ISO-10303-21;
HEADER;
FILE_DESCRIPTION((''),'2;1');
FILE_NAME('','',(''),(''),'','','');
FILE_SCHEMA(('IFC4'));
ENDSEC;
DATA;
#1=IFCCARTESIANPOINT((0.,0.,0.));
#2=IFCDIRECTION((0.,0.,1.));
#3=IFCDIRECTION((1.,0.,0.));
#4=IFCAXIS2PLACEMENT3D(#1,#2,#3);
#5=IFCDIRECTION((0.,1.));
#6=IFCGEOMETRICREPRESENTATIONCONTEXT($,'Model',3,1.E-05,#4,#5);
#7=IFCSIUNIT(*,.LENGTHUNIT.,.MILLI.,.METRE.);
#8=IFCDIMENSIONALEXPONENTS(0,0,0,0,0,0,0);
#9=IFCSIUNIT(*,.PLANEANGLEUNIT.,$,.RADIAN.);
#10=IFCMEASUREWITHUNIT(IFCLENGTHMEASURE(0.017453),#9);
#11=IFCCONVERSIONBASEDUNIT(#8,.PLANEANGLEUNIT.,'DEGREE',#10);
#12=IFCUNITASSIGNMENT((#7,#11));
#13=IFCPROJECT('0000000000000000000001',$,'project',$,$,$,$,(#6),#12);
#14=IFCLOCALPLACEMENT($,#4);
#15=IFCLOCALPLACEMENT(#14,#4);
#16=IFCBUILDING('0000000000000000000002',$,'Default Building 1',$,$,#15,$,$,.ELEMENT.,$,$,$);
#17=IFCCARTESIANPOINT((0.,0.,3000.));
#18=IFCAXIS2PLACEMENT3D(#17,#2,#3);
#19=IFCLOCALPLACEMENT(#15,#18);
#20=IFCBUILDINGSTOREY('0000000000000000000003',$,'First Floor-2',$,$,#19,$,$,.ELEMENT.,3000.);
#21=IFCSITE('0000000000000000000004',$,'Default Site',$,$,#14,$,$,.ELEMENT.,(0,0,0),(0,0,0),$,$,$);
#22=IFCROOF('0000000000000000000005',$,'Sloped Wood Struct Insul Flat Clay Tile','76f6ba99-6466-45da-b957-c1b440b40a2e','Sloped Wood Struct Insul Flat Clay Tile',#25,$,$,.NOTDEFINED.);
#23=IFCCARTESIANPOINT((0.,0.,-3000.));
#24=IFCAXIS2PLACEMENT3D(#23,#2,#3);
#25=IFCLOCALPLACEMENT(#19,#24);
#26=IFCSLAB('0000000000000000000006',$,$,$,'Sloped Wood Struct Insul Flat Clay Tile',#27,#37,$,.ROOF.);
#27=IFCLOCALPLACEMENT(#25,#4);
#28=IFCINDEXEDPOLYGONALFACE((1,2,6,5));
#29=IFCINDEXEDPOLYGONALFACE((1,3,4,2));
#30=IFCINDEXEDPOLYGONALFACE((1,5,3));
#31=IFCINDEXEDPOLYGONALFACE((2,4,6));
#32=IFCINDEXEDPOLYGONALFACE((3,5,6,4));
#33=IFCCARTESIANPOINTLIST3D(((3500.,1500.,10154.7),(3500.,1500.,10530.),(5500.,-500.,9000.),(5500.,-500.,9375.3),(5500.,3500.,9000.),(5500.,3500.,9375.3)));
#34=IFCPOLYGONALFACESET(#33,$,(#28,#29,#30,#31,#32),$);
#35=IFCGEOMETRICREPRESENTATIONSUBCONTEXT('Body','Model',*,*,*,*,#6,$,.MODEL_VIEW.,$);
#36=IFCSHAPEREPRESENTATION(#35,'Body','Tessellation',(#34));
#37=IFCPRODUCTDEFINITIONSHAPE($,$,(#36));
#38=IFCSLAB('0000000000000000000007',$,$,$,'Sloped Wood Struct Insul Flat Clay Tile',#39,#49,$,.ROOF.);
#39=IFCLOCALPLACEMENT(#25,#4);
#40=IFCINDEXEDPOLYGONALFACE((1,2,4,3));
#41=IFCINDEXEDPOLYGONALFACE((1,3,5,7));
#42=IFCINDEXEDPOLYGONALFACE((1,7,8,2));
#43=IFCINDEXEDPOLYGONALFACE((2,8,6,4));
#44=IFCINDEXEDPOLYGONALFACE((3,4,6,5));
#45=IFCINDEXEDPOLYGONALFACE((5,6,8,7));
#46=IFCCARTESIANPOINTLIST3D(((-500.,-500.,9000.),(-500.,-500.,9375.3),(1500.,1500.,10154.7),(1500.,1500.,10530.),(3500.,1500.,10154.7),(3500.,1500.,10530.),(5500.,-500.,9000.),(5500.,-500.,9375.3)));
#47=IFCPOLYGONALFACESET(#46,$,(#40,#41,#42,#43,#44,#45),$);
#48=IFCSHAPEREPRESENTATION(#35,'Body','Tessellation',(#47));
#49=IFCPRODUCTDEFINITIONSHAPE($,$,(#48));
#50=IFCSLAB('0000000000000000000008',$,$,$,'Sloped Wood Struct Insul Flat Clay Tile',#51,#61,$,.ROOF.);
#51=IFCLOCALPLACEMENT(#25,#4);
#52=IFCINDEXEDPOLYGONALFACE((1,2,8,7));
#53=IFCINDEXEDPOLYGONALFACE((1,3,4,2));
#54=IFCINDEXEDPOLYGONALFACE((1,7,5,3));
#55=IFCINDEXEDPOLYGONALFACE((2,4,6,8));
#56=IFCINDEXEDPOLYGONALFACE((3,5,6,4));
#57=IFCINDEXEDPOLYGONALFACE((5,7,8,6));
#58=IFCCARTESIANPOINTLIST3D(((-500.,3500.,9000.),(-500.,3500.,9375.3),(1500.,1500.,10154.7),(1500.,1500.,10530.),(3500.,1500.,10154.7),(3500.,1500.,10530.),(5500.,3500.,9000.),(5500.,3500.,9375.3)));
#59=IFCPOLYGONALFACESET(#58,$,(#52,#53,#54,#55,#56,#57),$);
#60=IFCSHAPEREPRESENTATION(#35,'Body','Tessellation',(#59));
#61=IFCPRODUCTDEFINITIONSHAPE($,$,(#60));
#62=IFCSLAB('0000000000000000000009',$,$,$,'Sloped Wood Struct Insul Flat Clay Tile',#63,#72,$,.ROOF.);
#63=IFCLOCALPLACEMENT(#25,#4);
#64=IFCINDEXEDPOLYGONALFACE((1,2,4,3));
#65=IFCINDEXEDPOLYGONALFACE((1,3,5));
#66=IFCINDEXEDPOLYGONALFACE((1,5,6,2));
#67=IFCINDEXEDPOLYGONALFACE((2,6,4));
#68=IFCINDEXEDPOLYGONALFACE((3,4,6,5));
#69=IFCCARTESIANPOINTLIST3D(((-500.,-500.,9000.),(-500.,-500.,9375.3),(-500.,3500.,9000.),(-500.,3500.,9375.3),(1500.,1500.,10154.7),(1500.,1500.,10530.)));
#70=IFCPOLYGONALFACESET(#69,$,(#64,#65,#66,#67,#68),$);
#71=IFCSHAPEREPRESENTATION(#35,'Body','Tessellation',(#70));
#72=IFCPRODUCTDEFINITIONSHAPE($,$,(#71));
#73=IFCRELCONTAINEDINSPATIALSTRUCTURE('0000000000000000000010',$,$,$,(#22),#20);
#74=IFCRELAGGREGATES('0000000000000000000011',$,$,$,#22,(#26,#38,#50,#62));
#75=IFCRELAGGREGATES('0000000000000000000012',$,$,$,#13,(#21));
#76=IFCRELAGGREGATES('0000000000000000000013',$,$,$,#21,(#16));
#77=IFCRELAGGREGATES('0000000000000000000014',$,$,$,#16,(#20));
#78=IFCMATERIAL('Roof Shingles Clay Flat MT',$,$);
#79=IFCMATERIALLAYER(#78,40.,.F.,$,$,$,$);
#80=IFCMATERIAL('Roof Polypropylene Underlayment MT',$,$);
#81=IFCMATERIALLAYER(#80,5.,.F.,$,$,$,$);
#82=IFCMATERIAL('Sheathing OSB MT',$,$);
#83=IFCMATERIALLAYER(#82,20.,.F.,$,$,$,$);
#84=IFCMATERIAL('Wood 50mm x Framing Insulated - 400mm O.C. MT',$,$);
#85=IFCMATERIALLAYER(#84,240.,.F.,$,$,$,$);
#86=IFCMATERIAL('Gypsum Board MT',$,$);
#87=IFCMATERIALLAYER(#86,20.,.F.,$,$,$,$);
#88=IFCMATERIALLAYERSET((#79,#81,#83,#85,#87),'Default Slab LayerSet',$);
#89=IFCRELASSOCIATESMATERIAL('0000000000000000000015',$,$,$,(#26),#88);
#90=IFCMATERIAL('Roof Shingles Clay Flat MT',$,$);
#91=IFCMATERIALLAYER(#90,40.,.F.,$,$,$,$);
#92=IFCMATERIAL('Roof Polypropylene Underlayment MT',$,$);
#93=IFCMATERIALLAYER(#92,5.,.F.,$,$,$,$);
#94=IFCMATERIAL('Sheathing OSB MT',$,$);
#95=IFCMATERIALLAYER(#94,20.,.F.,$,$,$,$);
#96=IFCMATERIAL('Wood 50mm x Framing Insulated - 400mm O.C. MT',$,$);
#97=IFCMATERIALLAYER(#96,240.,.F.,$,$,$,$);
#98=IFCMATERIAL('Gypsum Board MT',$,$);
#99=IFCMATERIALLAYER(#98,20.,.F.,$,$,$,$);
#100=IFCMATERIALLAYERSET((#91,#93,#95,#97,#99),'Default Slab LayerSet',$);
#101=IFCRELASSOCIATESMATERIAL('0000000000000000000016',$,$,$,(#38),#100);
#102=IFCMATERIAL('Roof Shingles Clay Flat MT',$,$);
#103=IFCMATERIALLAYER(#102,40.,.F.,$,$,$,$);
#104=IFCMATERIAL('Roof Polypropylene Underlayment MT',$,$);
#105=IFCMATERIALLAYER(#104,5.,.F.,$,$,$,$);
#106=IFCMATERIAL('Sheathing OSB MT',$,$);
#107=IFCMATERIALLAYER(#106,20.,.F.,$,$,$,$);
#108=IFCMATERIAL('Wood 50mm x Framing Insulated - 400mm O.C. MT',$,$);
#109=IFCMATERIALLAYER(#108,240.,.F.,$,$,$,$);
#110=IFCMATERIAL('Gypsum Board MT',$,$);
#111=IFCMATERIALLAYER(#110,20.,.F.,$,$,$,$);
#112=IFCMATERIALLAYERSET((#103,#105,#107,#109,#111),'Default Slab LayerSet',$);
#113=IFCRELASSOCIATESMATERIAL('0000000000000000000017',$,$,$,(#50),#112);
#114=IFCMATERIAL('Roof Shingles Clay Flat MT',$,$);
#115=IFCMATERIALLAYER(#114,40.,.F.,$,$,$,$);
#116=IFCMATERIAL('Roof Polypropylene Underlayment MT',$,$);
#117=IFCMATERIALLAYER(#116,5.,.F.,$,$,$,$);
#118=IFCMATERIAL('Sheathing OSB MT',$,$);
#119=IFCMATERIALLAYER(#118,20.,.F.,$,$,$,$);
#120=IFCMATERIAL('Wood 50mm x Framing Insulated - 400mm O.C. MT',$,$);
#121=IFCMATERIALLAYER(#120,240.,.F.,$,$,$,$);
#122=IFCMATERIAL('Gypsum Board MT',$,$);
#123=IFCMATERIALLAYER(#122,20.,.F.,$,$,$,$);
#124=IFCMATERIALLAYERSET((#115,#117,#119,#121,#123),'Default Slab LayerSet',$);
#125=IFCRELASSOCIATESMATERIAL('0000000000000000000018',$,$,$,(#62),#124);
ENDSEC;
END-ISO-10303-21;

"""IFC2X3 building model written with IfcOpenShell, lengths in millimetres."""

from ifc_helpers import new_model, entity, si_unit, converted_unit, direction, frame, origin_with_axes, place, context, subcontext, project, spatial, polyline, outline, extrude, material, layer, layer_set, layer_usage, element, aggregate, save


model = new_model("IFC2X3")

# Units and contexts
model_context = context("Model", 3, precision=1e-05, world=origin_with_axes(), true_north=direction((0.0, 1.0)))
body_context = subcontext(model_context, "Body", "Model", "MODEL_VIEW")
ifc_project = project(units=[si_unit("LENGTHUNIT", "METRE", prefix="MILLI"), converted_unit("PLANEANGLEUNIT", "DEGREE", entity("IfcLengthMeasure", 0.017453), si_unit("PLANEANGLEUNIT", "RADIAN"), dimensions=[0, 0, 0, 0, 0, 0, 0])], contexts=[model_context])

# Site, building, storey
site_placement = place(None, origin_with_axes())
site = spatial("IfcSite", under=ifc_project, at=site_placement, Name="Default Site", CompositionType="ELEMENT", RefLatitude=(0, 0, 0), RefLongitude=(0, 0, 0))
building_placement = place(site_placement, origin_with_axes())
building = spatial("IfcBuilding", under=site, at=building_placement, Name="Default Building 1", CompositionType="ELEMENT")
storey_placement = place(building_placement, frame((0.0, 0.0, 3000.0), z_axis=(0.0, 0.0, 1.0), x_axis=(1.0, 0.0, 0.0)))
storey = spatial("IfcBuildingStorey", under=building, at=storey_placement, Name="First Floor-2", CompositionType="ELEMENT", Elevation=3000.0)

# Roof, slabs
roof_placement = place(storey_placement, frame((0.0, 0.0, -3000.0), z_axis=(0.0, 0.0, 1.0), x_axis=(1.0, 0.0, 0.0)))
roof = element("IfcRoof", 1, at=roof_placement, inside=storey, Name="Sloped Wood Struct Insul Flat Clay Tile", Description="76f6ba99-6466-45da-b957-c1b440b40a2e", ObjectType="Sloped Wood Struct Insul Flat Clay Tile", ShapeType="NOTDEFINED")
ifc_material_1 = material(Name="Roof Shingles Clay Flat MT")
ifc_layer_1 = layer(ifc_material_1, 40.0, ventilated=False)
ifc_material_2 = material(Name="Roof Polypropylene Underlayment MT")
ifc_layer_2 = layer(ifc_material_2, 5.0, ventilated=False)
ifc_material_3 = material(Name="Sheathing OSB MT")
ifc_layer_3 = layer(ifc_material_3, 20.0, ventilated=False)
ifc_material_4 = material(Name="Wood 50mm x Framing Insulated - 400mm O.C. MT")
ifc_layer_4 = layer(ifc_material_4, 240.0, ventilated=False)
ifc_material_5 = material(Name="Gypsum Board MT")
ifc_layer_5 = layer(ifc_material_5, 20.0, ventilated=False)
ifc_layer_set_1 = layer_set([ifc_layer_1, ifc_layer_2, ifc_layer_3, ifc_layer_4, ifc_layer_5], Name="Default Slab LayerSet")
ifc_layer_usage_1 = layer_usage(ifc_layer_set_1, "AXIS3", "POSITIVE", 260.0)
slab_1_placement = place(roof_placement, origin_with_axes())
slab_1 = element("IfcSlab", 2, at=slab_1_placement, material=ifc_layer_usage_1, ObjectType="Sloped Wood Struct Insul Flat Clay Tile", PredefinedType="ROOF", context=body_context, shape_type="SweptSolid", body=[
    extrude(outline(polyline([(0.0, 0.0), (3055.1, 0.0), (2618.6, 3023.7), (0.0, 0.0)])), frame((5500.0, -500.0, 9000.0), z_axis=(-0.5, 0.0, -0.866025), x_axis=(-0.654654, 0.654654, 0.377964)), (0.377964, -0.327327, -0.866025), 375.3),
])
ifc_material_6 = material(Name="Roof Shingles Clay Flat MT")
ifc_layer_6 = layer(ifc_material_6, 40.0, ventilated=False)
ifc_material_7 = material(Name="Roof Polypropylene Underlayment MT")
ifc_layer_7 = layer(ifc_material_7, 5.0, ventilated=False)
ifc_material_8 = material(Name="Sheathing OSB MT")
ifc_layer_8 = layer(ifc_material_8, 20.0, ventilated=False)
ifc_material_9 = material(Name="Wood 50mm x Framing Insulated - 400mm O.C. MT")
ifc_layer_9 = layer(ifc_material_9, 240.0, ventilated=False)
ifc_material_10 = material(Name="Gypsum Board MT")
ifc_layer_10 = layer(ifc_material_10, 20.0, ventilated=False)
ifc_layer_set_2 = layer_set([ifc_layer_6, ifc_layer_7, ifc_layer_8, ifc_layer_9, ifc_layer_10], Name="Default Slab LayerSet")
ifc_layer_usage_2 = layer_usage(ifc_layer_set_2, "AXIS3", "POSITIVE", 260.0)
slab_2_placement = place(roof_placement, origin_with_axes())
slab_2 = element("IfcSlab", 3, at=slab_2_placement, material=ifc_layer_usage_2, ObjectType="Sloped Wood Struct Insul Flat Clay Tile", PredefinedType="ROOF", context=body_context, shape_type="SweptSolid", body=[
    extrude(outline(polyline([(0.0, 0.0), (6000.0, 0.0), (4000.0, 2309.4), (2000.0, 2309.4), (0.0, 0.0)])), frame((5500.0, -500.0, 9000.0), z_axis=(0.0, 0.5, -0.866025), x_axis=(-1.0, 0.0, 0.0)), (0.0, 0.5, -0.866025), 375.3),
])
ifc_material_11 = material(Name="Roof Shingles Clay Flat MT")
ifc_layer_11 = layer(ifc_material_11, 40.0, ventilated=False)
ifc_material_12 = material(Name="Roof Polypropylene Underlayment MT")
ifc_layer_12 = layer(ifc_material_12, 5.0, ventilated=False)
ifc_material_13 = material(Name="Sheathing OSB MT")
ifc_layer_13 = layer(ifc_material_13, 20.0, ventilated=False)
ifc_material_14 = material(Name="Wood 50mm x Framing Insulated - 400mm O.C. MT")
ifc_layer_14 = layer(ifc_material_14, 240.0, ventilated=False)
ifc_material_15 = material(Name="Gypsum Board MT")
ifc_layer_15 = layer(ifc_material_15, 20.0, ventilated=False)
ifc_layer_set_3 = layer_set([ifc_layer_11, ifc_layer_12, ifc_layer_13, ifc_layer_14, ifc_layer_15], Name="Default Slab LayerSet")
ifc_layer_usage_3 = layer_usage(ifc_layer_set_3, "AXIS3", "POSITIVE", 260.0)
slab_3_placement = place(roof_placement, origin_with_axes())
slab_3 = element("IfcSlab", 4, at=slab_3_placement, material=ifc_layer_usage_3, ObjectType="Sloped Wood Struct Insul Flat Clay Tile", PredefinedType="ROOF", context=body_context, shape_type="SweptSolid", body=[
    extrude(outline(polyline([(0.0, 0.0), (2000.0, 0.0), (4000.0, 2309.4), (-2000.0, 2309.4), (0.0, 0.0)])), frame((3500.0, 1500.0, 10154.7), z_axis=(0.0, -0.5, -0.866025), x_axis=(-1.0, 0.0, 0.0)), (0.0, -0.5, -0.866025), 375.3),
])
ifc_material_16 = material(Name="Roof Shingles Clay Flat MT")
ifc_layer_16 = layer(ifc_material_16, 40.0, ventilated=False)
ifc_material_17 = material(Name="Roof Polypropylene Underlayment MT")
ifc_layer_17 = layer(ifc_material_17, 5.0, ventilated=False)
ifc_material_18 = material(Name="Sheathing OSB MT")
ifc_layer_18 = layer(ifc_material_18, 20.0, ventilated=False)
ifc_material_19 = material(Name="Wood 50mm x Framing Insulated - 400mm O.C. MT")
ifc_layer_19 = layer(ifc_material_19, 240.0, ventilated=False)
ifc_material_20 = material(Name="Gypsum Board MT")
ifc_layer_20 = layer(ifc_material_20, 20.0, ventilated=False)
ifc_layer_set_4 = layer_set([ifc_layer_16, ifc_layer_17, ifc_layer_18, ifc_layer_19, ifc_layer_20], Name="Default Slab LayerSet")
ifc_layer_usage_4 = layer_usage(ifc_layer_set_4, "AXIS3", "POSITIVE", 260.0)
slab_4_placement = place(roof_placement, origin_with_axes())
slab_4 = element("IfcSlab", 5, at=slab_4_placement, material=ifc_layer_usage_4, ObjectType="Sloped Wood Struct Insul Flat Clay Tile", PredefinedType="ROOF", context=body_context, shape_type="SweptSolid", body=[
    extrude(outline(polyline([(0.0, 0.0), (3055.1, 0.0), (2618.6, 3023.7), (0.0, 0.0)])), frame((-500.0, 3500.0, 9000.0), z_axis=(0.5, 0.0, -0.866025), x_axis=(0.654654, -0.654654, 0.377964)), (0.377964, -0.327327, -0.866025), 375.3),
])
aggregate(roof, [slab_1, slab_2, slab_3, slab_4])

save(model, "model.ifc")
